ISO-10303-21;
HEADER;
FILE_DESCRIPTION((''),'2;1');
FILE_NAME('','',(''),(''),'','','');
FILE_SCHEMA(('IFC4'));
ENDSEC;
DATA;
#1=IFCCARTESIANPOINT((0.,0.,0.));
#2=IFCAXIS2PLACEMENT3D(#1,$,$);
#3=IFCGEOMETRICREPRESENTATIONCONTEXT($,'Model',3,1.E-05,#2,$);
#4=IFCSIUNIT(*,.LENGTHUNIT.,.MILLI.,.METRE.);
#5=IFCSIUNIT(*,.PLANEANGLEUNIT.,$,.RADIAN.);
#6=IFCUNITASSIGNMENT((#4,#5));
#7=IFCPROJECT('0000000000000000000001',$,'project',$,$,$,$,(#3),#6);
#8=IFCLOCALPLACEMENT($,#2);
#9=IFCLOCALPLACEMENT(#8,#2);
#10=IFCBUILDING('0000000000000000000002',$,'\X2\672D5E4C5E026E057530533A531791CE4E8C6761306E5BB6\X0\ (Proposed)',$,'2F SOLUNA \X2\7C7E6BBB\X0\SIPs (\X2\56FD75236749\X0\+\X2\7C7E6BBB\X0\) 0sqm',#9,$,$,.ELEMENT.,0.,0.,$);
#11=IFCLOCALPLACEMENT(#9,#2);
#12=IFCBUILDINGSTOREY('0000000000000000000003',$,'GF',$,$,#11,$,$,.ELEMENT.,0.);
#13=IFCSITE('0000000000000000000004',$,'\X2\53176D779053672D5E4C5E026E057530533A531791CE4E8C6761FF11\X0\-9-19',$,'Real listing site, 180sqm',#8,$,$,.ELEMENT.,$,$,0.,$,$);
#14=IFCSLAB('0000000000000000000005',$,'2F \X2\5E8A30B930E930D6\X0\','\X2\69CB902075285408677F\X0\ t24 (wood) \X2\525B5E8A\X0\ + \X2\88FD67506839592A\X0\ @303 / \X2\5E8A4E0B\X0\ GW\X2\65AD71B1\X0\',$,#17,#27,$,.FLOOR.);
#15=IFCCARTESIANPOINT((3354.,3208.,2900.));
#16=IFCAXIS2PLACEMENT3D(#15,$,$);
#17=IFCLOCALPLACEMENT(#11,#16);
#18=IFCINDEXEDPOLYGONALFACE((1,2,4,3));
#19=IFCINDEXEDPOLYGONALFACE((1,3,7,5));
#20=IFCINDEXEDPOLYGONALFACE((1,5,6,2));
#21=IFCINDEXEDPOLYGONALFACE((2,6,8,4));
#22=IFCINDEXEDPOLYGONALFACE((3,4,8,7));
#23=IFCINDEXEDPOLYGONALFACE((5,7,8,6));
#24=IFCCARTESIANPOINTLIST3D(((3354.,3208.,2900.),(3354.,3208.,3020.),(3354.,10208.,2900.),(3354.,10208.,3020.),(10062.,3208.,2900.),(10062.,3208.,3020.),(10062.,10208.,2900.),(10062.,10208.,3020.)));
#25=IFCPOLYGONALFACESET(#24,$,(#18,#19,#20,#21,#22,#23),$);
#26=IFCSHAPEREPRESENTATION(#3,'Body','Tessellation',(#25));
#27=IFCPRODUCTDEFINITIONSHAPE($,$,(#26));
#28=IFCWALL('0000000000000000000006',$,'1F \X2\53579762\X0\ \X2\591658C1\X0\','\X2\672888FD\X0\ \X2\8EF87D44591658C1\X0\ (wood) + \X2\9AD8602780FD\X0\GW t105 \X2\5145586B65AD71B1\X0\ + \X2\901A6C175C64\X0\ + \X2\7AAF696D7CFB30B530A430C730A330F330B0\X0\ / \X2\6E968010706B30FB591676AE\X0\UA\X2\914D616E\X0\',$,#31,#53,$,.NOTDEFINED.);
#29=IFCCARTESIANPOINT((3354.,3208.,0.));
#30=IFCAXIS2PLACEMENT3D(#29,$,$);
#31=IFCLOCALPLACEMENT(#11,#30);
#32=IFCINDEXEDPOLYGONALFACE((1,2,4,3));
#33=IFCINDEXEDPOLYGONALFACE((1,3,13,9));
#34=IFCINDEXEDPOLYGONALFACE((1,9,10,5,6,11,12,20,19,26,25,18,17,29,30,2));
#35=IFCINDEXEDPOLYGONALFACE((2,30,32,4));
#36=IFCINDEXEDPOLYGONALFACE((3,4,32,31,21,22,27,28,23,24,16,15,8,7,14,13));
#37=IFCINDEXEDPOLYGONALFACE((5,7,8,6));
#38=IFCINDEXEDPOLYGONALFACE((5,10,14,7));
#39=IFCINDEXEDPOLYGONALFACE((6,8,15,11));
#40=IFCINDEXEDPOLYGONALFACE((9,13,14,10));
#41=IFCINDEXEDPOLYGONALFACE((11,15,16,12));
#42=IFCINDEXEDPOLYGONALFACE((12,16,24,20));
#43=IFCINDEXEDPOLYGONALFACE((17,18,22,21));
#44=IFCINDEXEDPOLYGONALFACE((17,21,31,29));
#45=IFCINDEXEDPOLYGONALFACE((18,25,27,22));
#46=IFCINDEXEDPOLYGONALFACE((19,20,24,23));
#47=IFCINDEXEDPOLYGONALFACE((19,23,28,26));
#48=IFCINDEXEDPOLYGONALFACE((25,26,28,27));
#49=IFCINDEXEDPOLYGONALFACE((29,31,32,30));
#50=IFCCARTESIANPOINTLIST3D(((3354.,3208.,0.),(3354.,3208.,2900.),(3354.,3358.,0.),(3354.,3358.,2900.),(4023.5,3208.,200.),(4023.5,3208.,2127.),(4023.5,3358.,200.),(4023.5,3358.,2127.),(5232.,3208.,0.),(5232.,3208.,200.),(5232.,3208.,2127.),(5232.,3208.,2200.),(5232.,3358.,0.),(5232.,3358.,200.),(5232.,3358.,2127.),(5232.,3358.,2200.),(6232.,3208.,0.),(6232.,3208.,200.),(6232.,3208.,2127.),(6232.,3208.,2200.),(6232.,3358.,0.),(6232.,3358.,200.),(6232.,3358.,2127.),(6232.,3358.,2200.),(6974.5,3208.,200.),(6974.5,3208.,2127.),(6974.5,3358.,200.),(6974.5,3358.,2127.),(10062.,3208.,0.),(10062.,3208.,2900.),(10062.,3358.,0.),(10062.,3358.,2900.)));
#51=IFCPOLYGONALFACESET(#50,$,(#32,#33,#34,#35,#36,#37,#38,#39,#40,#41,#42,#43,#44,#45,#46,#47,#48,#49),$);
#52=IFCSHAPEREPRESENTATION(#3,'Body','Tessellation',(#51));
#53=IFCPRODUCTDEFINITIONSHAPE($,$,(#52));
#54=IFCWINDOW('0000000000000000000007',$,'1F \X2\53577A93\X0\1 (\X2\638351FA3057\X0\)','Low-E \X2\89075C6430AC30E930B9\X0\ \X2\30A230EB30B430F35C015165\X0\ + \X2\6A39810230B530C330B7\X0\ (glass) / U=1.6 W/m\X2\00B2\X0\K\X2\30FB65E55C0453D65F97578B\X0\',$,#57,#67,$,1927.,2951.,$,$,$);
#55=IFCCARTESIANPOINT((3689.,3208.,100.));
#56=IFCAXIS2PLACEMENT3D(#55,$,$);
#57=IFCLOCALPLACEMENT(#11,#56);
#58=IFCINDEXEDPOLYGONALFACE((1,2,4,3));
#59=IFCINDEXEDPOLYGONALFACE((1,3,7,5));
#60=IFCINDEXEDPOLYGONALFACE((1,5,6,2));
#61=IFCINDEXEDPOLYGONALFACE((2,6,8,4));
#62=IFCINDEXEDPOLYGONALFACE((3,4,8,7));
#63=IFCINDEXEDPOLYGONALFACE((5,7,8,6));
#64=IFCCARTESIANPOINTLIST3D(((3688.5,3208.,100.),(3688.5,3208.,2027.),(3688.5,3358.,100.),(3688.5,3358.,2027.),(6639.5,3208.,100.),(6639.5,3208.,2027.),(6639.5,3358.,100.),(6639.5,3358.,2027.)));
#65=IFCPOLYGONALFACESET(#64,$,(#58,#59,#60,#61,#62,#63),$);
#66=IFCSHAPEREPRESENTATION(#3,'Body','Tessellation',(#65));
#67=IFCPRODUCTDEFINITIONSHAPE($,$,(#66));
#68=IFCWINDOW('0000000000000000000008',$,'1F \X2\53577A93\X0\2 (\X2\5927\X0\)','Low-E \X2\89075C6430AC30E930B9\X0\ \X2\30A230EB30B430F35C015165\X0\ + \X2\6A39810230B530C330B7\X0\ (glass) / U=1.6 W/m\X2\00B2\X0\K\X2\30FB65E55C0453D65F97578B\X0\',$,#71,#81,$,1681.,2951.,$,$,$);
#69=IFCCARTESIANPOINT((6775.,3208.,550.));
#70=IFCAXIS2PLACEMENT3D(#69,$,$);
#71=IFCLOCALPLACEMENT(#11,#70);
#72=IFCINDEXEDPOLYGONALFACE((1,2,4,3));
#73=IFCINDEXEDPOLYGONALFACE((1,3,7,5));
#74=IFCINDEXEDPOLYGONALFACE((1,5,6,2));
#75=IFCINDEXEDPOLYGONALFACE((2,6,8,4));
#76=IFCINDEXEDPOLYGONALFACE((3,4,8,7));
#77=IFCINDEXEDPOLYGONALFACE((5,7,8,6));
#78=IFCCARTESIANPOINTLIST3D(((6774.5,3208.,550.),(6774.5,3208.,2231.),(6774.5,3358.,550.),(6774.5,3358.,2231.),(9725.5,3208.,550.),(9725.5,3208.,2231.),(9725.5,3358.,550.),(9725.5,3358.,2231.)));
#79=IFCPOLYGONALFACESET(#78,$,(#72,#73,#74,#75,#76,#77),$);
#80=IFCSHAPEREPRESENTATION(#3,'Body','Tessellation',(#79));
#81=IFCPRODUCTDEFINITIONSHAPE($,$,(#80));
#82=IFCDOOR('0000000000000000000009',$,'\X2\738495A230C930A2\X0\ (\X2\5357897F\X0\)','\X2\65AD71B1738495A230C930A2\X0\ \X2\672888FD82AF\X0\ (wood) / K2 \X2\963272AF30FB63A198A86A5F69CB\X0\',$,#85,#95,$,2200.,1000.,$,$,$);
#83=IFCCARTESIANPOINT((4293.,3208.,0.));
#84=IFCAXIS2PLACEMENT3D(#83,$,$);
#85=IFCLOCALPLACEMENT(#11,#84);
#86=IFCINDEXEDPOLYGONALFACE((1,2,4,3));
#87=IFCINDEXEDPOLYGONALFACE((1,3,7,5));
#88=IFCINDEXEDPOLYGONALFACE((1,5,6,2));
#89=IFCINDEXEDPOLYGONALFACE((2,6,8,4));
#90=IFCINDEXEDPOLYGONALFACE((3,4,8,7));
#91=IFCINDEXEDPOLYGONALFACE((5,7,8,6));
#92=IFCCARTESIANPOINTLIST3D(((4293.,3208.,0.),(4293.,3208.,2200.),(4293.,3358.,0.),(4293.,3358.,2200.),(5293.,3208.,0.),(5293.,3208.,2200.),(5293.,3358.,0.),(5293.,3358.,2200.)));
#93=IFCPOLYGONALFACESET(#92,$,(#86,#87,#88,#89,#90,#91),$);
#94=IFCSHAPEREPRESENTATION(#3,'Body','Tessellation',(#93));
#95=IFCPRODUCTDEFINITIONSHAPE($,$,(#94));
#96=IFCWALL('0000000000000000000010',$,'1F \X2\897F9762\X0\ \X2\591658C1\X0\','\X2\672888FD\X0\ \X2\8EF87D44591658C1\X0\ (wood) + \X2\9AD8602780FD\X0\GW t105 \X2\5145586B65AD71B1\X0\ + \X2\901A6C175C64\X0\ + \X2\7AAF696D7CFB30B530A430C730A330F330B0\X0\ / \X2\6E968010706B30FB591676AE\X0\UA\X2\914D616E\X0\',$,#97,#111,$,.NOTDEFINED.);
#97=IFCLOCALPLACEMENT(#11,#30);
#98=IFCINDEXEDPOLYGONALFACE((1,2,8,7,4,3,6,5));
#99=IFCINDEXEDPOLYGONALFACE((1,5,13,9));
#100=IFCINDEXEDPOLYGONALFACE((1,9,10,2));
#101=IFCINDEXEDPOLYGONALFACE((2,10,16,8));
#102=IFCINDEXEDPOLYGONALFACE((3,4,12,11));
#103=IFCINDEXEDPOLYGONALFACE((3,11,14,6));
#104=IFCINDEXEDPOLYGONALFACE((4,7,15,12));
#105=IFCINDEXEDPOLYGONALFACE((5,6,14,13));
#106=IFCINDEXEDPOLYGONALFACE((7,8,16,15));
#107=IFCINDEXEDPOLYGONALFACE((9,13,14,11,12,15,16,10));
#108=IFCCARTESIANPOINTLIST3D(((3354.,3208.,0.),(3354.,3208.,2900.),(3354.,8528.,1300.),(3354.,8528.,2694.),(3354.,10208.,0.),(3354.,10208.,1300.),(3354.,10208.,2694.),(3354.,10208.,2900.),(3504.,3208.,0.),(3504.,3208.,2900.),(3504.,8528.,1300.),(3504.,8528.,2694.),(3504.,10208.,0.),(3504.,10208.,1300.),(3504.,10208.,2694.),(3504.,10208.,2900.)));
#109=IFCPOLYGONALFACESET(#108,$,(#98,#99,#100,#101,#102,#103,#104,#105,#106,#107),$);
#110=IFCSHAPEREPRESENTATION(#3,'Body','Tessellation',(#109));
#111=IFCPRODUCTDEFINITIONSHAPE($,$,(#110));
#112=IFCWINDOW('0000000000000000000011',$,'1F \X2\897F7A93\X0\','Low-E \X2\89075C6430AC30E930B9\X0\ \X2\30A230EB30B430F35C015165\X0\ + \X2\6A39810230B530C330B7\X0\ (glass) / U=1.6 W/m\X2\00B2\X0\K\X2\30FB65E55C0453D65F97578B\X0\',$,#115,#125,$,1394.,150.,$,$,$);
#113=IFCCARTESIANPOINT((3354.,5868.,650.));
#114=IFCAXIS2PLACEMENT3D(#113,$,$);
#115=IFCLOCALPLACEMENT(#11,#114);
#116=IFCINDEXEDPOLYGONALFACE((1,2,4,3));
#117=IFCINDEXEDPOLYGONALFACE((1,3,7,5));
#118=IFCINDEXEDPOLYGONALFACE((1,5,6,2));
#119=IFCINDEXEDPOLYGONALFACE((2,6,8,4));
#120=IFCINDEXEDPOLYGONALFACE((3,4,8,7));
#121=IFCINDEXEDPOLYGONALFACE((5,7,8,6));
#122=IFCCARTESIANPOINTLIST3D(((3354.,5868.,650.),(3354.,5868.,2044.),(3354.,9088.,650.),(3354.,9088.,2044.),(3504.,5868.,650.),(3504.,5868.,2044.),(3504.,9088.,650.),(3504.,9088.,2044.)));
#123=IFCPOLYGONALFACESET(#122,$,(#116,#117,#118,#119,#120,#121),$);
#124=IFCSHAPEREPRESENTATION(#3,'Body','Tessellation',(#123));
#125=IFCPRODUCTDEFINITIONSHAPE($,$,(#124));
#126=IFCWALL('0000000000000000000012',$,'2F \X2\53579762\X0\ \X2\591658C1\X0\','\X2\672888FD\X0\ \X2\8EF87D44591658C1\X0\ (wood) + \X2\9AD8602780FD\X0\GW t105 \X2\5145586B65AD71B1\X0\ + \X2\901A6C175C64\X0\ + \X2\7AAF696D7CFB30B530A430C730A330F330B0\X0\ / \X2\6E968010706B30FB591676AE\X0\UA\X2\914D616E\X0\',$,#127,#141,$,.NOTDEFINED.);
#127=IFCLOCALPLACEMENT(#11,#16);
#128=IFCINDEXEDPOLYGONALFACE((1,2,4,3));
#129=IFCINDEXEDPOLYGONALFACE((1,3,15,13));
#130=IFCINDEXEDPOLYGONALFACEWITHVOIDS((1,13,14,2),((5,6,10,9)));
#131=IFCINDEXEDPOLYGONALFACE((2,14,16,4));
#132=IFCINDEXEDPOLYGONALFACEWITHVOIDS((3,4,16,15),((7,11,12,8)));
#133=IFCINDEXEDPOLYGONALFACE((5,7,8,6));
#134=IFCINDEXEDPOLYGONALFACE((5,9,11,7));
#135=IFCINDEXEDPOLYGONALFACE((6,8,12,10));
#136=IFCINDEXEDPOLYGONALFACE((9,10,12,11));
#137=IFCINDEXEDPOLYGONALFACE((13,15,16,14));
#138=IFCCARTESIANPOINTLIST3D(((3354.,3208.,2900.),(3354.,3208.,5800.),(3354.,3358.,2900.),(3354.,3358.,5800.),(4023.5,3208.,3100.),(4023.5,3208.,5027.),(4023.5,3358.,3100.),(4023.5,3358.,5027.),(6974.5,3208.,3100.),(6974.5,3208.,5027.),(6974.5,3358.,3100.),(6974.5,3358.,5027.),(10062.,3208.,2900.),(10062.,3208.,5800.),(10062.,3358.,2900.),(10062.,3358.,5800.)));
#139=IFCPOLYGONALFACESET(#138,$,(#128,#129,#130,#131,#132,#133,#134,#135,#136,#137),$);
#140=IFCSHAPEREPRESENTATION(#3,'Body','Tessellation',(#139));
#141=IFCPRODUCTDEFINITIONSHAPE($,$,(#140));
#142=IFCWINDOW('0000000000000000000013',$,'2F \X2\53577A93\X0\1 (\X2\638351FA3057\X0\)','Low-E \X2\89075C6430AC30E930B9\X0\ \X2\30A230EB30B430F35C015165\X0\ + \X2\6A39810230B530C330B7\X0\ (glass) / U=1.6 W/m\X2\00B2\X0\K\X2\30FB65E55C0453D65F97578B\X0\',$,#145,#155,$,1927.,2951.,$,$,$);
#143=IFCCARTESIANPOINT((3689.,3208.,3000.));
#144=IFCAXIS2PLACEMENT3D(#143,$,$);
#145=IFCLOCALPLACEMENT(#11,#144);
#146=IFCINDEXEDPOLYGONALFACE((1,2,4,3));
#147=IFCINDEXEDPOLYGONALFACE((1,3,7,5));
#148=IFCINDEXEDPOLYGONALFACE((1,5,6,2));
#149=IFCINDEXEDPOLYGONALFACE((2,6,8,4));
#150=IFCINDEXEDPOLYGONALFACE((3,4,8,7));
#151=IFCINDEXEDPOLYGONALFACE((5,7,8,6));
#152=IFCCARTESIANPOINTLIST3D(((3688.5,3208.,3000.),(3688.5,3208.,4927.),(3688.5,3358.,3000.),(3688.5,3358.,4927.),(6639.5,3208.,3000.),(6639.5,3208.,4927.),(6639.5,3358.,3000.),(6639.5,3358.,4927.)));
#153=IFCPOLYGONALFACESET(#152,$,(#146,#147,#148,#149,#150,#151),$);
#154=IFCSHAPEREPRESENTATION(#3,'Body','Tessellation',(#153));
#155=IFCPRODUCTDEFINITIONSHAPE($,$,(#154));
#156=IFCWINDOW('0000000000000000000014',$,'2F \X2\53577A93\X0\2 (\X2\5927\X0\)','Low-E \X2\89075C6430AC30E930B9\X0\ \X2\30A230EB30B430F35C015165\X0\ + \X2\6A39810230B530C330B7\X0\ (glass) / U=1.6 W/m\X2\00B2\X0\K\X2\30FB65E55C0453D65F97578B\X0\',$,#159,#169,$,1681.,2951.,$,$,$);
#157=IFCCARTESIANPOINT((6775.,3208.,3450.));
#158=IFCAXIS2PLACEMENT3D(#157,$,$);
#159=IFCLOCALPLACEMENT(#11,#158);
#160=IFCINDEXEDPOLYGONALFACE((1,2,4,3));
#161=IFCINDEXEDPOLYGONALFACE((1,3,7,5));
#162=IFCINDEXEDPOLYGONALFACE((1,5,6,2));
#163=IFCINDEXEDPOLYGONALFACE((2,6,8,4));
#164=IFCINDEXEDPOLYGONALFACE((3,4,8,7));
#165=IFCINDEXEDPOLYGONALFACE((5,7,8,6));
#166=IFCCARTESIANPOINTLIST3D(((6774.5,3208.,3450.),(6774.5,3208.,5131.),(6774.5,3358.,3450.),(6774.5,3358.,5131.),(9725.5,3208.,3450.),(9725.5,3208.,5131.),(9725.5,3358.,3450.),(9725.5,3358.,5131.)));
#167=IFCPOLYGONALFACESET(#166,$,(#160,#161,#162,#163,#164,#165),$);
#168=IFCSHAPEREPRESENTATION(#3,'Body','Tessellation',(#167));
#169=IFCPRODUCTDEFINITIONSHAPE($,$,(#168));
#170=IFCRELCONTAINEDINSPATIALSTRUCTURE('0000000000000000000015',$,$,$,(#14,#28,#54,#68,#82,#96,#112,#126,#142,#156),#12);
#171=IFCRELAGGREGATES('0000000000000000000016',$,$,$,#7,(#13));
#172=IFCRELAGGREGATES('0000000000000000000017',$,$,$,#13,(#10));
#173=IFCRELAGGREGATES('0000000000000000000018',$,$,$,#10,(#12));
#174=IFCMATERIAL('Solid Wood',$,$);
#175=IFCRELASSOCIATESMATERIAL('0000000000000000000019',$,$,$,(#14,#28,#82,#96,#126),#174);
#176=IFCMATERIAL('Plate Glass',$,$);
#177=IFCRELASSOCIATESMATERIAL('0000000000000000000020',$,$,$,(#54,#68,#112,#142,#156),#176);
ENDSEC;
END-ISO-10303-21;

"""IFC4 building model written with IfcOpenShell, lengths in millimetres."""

from ifc_helpers import new_model, si_unit, frame, frame_2d, origin, place, context, project, spatial, rectangle, extrude, material, element, fill, save


model = new_model("IFC4")

# Units and contexts
model_context = context("Model", 3, precision=1e-05, world=origin())
ifc_project = project(units=[si_unit("LENGTHUNIT", "METRE", prefix="MILLI"), si_unit("PLANEANGLEUNIT", "RADIAN")], contexts=[model_context])

# Site, building, storey
site_placement = place(None, origin())
site = spatial("IfcSite", under=ifc_project, at=site_placement, Name="北海道札幌市清田区北野二条１-9-19", ObjectType="Real listing site, 180sqm", CompositionType="ELEMENT", RefElevation=0.0)
building_placement = place(site_placement, origin())
building = spatial("IfcBuilding", under=site, at=building_placement, Name="札幌市清田区北野二条の家 (Proposed)", ObjectType="2F SOLUNA 籾殻SIPs (国産杉+籾殻) 0sqm", CompositionType="ELEMENT", ElevationOfRefHeight=0.0, ElevationOfTerrain=0.0)
storey_placement = place(building_placement, origin())
storey = spatial("IfcBuildingStorey", under=building, at=storey_placement, Name="GF", CompositionType="ELEMENT", Elevation=0.0)

# Slab
ifc_material_1 = material(Name="Solid Wood")
slab_1_placement = place(storey_placement, frame((3354.0, 3208.0, 2900.0)))
element("IfcSlab", 1, at=slab_1_placement, inside=storey, material=ifc_material_1, Name="2F 床スラブ", Description="構造用合板 t24 (wood) 剛床 + 製材根太 @303 / 床下 GW断熱", PredefinedType="FLOOR", context=model_context, shape_type="SweptSolid", body=[
    extrude(rectangle(XDim=6708.0, YDim=7000.0, at=frame_2d((3354.0, 3500.0))), frame((3354.0, 3208.0, 2900.0)), (0.0, 0.0, 1.0), 120.0),
])

# Wall, openings, windows, door
wall_1_placement = place(storey_placement, frame((3354.0, 3208.0, 0.0)))
wall_1 = element("IfcWall", 2, at=wall_1_placement, inside=storey, material=ifc_material_1, Name="1F 南面 外壁", Description="木製 軸組外壁 (wood) + 高性能GW t105 充填断熱 + 通気層 + 窯業系サイディング / 準耐火・外皮UA配慮", PredefinedType="NOTDEFINED", context=model_context, shape_type="SweptSolid", body=[
    extrude(rectangle(XDim=6708.0, YDim=150.0, at=frame_2d((3354.0, 75.0))), frame((3354.0, 3208.0, 0.0)), (0.0, 0.0, 1.0), 2900.0),
])
opening_1_placement = place(storey_placement, frame((3689.0, 3208.0, 100.0)))
opening_1 = element("IfcOpeningElement", 3, at=opening_1_placement, cuts=wall_1, PredefinedType="NOTDEFINED", context=model_context, shape_type="SweptSolid", body=[
    extrude(rectangle(XDim=2951.0, YDim=150.0, at=frame_2d((1475.0, 75.0))), frame((3689.0, 3208.0, 100.0)), (0.0, 0.0, 1.0), 1927.0),
])
opening_2_placement = place(storey_placement, frame((6775.0, 3208.0, 550.0)))
opening_2 = element("IfcOpeningElement", 4, at=opening_2_placement, cuts=wall_1, PredefinedType="NOTDEFINED", context=model_context, shape_type="SweptSolid", body=[
    extrude(rectangle(XDim=2951.0, YDim=150.0, at=frame_2d((1475.0, 75.0))), frame((6775.0, 3208.0, 550.0)), (0.0, 0.0, 1.0), 1681.0),
])
opening_3_placement = place(storey_placement, frame((4293.0, 3208.0, 0.0)))
opening_3 = element("IfcOpeningElement", 5, at=opening_3_placement, cuts=wall_1, PredefinedType="NOTDEFINED", context=model_context, shape_type="SweptSolid", body=[
    extrude(rectangle(XDim=1000.0, YDim=150.0, at=frame_2d((500.0, 75.0))), frame((4293.0, 3208.0, 0.0)), (0.0, 0.0, 1.0), 2200.0),
])
ifc_material_2 = material(Name="Plate Glass")
window_1_placement = place(storey_placement, frame((3689.0, 3208.0, 100.0)))
window_1 = element("IfcWindow", 6, at=window_1_placement, inside=storey, material=ifc_material_2, Name="1F 南窓1 (掃出し)", Description="Low-E 複層ガラス アルゴン封入 + 樹脂サッシ (glass) / U=1.6 W/m²K・日射取得型", OverallHeight=1927.0, OverallWidth=2951.0, context=model_context, shape_type="SweptSolid", body=[
    extrude(rectangle(XDim=2951.0, YDim=150.0, at=frame_2d((1475.0, 75.0))), frame((3689.0, 3208.0, 100.0)), (0.0, 0.0, 1.0), 1927.0),
])
fill(opening_1, window_1)
window_2_placement = place(storey_placement, frame((6775.0, 3208.0, 550.0)))
window_2 = element("IfcWindow", 7, at=window_2_placement, inside=storey, material=ifc_material_2, Name="1F 南窓2 (大)", Description="Low-E 複層ガラス アルゴン封入 + 樹脂サッシ (glass) / U=1.6 W/m²K・日射取得型", OverallHeight=1681.0, OverallWidth=2951.0, context=model_context, shape_type="SweptSolid", body=[
    extrude(rectangle(XDim=2951.0, YDim=150.0, at=frame_2d((1475.0, 75.0))), frame((6775.0, 3208.0, 550.0)), (0.0, 0.0, 1.0), 1681.0),
])
fill(opening_2, window_2)
door_placement = place(storey_placement, frame((4293.0, 3208.0, 0.0)))
door = element("IfcDoor", 8, at=door_placement, inside=storey, material=ifc_material_1, Name="玄関ドア (南西)", Description="断熱玄関ドア 木製芯 (wood) / K2 防犯・採風機構", OverallHeight=2200.0, OverallWidth=1000.0, context=model_context, shape_type="SweptSolid", body=[
    extrude(rectangle(XDim=1000.0, YDim=150.0, at=frame_2d((500.0, 75.0))), frame((4293.0, 3208.0, 0.0)), (0.0, 0.0, 1.0), 2200.0),
])
fill(opening_3, door)

# Wall, opening, window
wall_2_placement = place(storey_placement, frame((3354.0, 3208.0, 0.0)))
wall_2 = element("IfcWall", 9, at=wall_2_placement, inside=storey, material=ifc_material_1, Name="1F 西面 外壁", Description="木製 軸組外壁 (wood) + 高性能GW t105 充填断熱 + 通気層 + 窯業系サイディング / 準耐火・外皮UA配慮", PredefinedType="NOTDEFINED", context=model_context, shape_type="SweptSolid", body=[
    extrude(rectangle(XDim=150.0, YDim=7000.0, at=frame_2d((75.0, 3500.0))), frame((3354.0, 3208.0, 0.0)), (0.0, 0.0, 1.0), 2900.0),
])
opening_4_placement = place(storey_placement, frame((3354.0, 5868.0, 650.0)))
opening_4 = element("IfcOpeningElement", 10, at=opening_4_placement, cuts=wall_2, PredefinedType="NOTDEFINED", context=model_context, shape_type="SweptSolid", body=[
    extrude(rectangle(XDim=150.0, YDim=3220.0, at=frame_2d((75.0, 1610.0))), frame((3354.0, 5868.0, 650.0)), (0.0, 0.0, 1.0), 1394.0),
])
window_3_placement = place(storey_placement, frame((3354.0, 5868.0, 650.0)))
window_3 = element("IfcWindow", 11, at=window_3_placement, inside=storey, material=ifc_material_2, Name="1F 西窓", Description="Low-E 複層ガラス アルゴン封入 + 樹脂サッシ (glass) / U=1.6 W/m²K・日射取得型", OverallHeight=1394.0, OverallWidth=150.0, context=model_context, shape_type="SweptSolid", body=[
    extrude(rectangle(XDim=150.0, YDim=3220.0, at=frame_2d((75.0, 1610.0))), frame((3354.0, 5868.0, 650.0)), (0.0, 0.0, 1.0), 1394.0),
])
fill(opening_4, window_3)

# Wall, openings, windows
wall_3_placement = place(storey_placement, frame((3354.0, 3208.0, 2900.0)))
wall_3 = element("IfcWall", 12, at=wall_3_placement, inside=storey, material=ifc_material_1, Name="2F 南面 外壁", Description="木製 軸組外壁 (wood) + 高性能GW t105 充填断熱 + 通気層 + 窯業系サイディング / 準耐火・外皮UA配慮", PredefinedType="NOTDEFINED", context=model_context, shape_type="SweptSolid", body=[
    extrude(rectangle(XDim=6708.0, YDim=150.0, at=frame_2d((3354.0, 75.0))), frame((3354.0, 3208.0, 2900.0)), (0.0, 0.0, 1.0), 2900.0),
])
opening_5_placement = place(storey_placement, frame((3689.0, 3208.0, 3000.0)))
opening_5 = element("IfcOpeningElement", 13, at=opening_5_placement, cuts=wall_3, PredefinedType="NOTDEFINED", context=model_context, shape_type="SweptSolid", body=[
    extrude(rectangle(XDim=2951.0, YDim=150.0, at=frame_2d((1475.0, 75.0))), frame((3689.0, 3208.0, 3000.0)), (0.0, 0.0, 1.0), 1927.0),
])
opening_6_placement = place(storey_placement, frame((6775.0, 3208.0, 3450.0)))
opening_6 = element("IfcOpeningElement", 14, at=opening_6_placement, cuts=wall_3, PredefinedType="NOTDEFINED", context=model_context, shape_type="SweptSolid", body=[
    extrude(rectangle(XDim=2951.0, YDim=150.0, at=frame_2d((1475.0, 75.0))), frame((6775.0, 3208.0, 3450.0)), (0.0, 0.0, 1.0), 1681.0),
])
window_4_placement = place(storey_placement, frame((3689.0, 3208.0, 3000.0)))
window_4 = element("IfcWindow", 15, at=window_4_placement, inside=storey, material=ifc_material_2, Name="2F 南窓1 (掃出し)", Description="Low-E 複層ガラス アルゴン封入 + 樹脂サッシ (glass) / U=1.6 W/m²K・日射取得型", OverallHeight=1927.0, OverallWidth=2951.0, context=model_context, shape_type="SweptSolid", body=[
    extrude(rectangle(XDim=2951.0, YDim=150.0, at=frame_2d((1475.0, 75.0))), frame((3689.0, 3208.0, 3000.0)), (0.0, 0.0, 1.0), 1927.0),
])
fill(opening_5, window_4)
window_5_placement = place(storey_placement, frame((6775.0, 3208.0, 3450.0)))
window_5 = element("IfcWindow", 16, at=window_5_placement, inside=storey, material=ifc_material_2, Name="2F 南窓2 (大)", Description="Low-E 複層ガラス アルゴン封入 + 樹脂サッシ (glass) / U=1.6 W/m²K・日射取得型", OverallHeight=1681.0, OverallWidth=2951.0, context=model_context, shape_type="SweptSolid", body=[
    extrude(rectangle(XDim=2951.0, YDim=150.0, at=frame_2d((1475.0, 75.0))), frame((6775.0, 3208.0, 3450.0)), (0.0, 0.0, 1.0), 1681.0),
])
fill(opening_6, window_5)

save(model, "model.ifc")
